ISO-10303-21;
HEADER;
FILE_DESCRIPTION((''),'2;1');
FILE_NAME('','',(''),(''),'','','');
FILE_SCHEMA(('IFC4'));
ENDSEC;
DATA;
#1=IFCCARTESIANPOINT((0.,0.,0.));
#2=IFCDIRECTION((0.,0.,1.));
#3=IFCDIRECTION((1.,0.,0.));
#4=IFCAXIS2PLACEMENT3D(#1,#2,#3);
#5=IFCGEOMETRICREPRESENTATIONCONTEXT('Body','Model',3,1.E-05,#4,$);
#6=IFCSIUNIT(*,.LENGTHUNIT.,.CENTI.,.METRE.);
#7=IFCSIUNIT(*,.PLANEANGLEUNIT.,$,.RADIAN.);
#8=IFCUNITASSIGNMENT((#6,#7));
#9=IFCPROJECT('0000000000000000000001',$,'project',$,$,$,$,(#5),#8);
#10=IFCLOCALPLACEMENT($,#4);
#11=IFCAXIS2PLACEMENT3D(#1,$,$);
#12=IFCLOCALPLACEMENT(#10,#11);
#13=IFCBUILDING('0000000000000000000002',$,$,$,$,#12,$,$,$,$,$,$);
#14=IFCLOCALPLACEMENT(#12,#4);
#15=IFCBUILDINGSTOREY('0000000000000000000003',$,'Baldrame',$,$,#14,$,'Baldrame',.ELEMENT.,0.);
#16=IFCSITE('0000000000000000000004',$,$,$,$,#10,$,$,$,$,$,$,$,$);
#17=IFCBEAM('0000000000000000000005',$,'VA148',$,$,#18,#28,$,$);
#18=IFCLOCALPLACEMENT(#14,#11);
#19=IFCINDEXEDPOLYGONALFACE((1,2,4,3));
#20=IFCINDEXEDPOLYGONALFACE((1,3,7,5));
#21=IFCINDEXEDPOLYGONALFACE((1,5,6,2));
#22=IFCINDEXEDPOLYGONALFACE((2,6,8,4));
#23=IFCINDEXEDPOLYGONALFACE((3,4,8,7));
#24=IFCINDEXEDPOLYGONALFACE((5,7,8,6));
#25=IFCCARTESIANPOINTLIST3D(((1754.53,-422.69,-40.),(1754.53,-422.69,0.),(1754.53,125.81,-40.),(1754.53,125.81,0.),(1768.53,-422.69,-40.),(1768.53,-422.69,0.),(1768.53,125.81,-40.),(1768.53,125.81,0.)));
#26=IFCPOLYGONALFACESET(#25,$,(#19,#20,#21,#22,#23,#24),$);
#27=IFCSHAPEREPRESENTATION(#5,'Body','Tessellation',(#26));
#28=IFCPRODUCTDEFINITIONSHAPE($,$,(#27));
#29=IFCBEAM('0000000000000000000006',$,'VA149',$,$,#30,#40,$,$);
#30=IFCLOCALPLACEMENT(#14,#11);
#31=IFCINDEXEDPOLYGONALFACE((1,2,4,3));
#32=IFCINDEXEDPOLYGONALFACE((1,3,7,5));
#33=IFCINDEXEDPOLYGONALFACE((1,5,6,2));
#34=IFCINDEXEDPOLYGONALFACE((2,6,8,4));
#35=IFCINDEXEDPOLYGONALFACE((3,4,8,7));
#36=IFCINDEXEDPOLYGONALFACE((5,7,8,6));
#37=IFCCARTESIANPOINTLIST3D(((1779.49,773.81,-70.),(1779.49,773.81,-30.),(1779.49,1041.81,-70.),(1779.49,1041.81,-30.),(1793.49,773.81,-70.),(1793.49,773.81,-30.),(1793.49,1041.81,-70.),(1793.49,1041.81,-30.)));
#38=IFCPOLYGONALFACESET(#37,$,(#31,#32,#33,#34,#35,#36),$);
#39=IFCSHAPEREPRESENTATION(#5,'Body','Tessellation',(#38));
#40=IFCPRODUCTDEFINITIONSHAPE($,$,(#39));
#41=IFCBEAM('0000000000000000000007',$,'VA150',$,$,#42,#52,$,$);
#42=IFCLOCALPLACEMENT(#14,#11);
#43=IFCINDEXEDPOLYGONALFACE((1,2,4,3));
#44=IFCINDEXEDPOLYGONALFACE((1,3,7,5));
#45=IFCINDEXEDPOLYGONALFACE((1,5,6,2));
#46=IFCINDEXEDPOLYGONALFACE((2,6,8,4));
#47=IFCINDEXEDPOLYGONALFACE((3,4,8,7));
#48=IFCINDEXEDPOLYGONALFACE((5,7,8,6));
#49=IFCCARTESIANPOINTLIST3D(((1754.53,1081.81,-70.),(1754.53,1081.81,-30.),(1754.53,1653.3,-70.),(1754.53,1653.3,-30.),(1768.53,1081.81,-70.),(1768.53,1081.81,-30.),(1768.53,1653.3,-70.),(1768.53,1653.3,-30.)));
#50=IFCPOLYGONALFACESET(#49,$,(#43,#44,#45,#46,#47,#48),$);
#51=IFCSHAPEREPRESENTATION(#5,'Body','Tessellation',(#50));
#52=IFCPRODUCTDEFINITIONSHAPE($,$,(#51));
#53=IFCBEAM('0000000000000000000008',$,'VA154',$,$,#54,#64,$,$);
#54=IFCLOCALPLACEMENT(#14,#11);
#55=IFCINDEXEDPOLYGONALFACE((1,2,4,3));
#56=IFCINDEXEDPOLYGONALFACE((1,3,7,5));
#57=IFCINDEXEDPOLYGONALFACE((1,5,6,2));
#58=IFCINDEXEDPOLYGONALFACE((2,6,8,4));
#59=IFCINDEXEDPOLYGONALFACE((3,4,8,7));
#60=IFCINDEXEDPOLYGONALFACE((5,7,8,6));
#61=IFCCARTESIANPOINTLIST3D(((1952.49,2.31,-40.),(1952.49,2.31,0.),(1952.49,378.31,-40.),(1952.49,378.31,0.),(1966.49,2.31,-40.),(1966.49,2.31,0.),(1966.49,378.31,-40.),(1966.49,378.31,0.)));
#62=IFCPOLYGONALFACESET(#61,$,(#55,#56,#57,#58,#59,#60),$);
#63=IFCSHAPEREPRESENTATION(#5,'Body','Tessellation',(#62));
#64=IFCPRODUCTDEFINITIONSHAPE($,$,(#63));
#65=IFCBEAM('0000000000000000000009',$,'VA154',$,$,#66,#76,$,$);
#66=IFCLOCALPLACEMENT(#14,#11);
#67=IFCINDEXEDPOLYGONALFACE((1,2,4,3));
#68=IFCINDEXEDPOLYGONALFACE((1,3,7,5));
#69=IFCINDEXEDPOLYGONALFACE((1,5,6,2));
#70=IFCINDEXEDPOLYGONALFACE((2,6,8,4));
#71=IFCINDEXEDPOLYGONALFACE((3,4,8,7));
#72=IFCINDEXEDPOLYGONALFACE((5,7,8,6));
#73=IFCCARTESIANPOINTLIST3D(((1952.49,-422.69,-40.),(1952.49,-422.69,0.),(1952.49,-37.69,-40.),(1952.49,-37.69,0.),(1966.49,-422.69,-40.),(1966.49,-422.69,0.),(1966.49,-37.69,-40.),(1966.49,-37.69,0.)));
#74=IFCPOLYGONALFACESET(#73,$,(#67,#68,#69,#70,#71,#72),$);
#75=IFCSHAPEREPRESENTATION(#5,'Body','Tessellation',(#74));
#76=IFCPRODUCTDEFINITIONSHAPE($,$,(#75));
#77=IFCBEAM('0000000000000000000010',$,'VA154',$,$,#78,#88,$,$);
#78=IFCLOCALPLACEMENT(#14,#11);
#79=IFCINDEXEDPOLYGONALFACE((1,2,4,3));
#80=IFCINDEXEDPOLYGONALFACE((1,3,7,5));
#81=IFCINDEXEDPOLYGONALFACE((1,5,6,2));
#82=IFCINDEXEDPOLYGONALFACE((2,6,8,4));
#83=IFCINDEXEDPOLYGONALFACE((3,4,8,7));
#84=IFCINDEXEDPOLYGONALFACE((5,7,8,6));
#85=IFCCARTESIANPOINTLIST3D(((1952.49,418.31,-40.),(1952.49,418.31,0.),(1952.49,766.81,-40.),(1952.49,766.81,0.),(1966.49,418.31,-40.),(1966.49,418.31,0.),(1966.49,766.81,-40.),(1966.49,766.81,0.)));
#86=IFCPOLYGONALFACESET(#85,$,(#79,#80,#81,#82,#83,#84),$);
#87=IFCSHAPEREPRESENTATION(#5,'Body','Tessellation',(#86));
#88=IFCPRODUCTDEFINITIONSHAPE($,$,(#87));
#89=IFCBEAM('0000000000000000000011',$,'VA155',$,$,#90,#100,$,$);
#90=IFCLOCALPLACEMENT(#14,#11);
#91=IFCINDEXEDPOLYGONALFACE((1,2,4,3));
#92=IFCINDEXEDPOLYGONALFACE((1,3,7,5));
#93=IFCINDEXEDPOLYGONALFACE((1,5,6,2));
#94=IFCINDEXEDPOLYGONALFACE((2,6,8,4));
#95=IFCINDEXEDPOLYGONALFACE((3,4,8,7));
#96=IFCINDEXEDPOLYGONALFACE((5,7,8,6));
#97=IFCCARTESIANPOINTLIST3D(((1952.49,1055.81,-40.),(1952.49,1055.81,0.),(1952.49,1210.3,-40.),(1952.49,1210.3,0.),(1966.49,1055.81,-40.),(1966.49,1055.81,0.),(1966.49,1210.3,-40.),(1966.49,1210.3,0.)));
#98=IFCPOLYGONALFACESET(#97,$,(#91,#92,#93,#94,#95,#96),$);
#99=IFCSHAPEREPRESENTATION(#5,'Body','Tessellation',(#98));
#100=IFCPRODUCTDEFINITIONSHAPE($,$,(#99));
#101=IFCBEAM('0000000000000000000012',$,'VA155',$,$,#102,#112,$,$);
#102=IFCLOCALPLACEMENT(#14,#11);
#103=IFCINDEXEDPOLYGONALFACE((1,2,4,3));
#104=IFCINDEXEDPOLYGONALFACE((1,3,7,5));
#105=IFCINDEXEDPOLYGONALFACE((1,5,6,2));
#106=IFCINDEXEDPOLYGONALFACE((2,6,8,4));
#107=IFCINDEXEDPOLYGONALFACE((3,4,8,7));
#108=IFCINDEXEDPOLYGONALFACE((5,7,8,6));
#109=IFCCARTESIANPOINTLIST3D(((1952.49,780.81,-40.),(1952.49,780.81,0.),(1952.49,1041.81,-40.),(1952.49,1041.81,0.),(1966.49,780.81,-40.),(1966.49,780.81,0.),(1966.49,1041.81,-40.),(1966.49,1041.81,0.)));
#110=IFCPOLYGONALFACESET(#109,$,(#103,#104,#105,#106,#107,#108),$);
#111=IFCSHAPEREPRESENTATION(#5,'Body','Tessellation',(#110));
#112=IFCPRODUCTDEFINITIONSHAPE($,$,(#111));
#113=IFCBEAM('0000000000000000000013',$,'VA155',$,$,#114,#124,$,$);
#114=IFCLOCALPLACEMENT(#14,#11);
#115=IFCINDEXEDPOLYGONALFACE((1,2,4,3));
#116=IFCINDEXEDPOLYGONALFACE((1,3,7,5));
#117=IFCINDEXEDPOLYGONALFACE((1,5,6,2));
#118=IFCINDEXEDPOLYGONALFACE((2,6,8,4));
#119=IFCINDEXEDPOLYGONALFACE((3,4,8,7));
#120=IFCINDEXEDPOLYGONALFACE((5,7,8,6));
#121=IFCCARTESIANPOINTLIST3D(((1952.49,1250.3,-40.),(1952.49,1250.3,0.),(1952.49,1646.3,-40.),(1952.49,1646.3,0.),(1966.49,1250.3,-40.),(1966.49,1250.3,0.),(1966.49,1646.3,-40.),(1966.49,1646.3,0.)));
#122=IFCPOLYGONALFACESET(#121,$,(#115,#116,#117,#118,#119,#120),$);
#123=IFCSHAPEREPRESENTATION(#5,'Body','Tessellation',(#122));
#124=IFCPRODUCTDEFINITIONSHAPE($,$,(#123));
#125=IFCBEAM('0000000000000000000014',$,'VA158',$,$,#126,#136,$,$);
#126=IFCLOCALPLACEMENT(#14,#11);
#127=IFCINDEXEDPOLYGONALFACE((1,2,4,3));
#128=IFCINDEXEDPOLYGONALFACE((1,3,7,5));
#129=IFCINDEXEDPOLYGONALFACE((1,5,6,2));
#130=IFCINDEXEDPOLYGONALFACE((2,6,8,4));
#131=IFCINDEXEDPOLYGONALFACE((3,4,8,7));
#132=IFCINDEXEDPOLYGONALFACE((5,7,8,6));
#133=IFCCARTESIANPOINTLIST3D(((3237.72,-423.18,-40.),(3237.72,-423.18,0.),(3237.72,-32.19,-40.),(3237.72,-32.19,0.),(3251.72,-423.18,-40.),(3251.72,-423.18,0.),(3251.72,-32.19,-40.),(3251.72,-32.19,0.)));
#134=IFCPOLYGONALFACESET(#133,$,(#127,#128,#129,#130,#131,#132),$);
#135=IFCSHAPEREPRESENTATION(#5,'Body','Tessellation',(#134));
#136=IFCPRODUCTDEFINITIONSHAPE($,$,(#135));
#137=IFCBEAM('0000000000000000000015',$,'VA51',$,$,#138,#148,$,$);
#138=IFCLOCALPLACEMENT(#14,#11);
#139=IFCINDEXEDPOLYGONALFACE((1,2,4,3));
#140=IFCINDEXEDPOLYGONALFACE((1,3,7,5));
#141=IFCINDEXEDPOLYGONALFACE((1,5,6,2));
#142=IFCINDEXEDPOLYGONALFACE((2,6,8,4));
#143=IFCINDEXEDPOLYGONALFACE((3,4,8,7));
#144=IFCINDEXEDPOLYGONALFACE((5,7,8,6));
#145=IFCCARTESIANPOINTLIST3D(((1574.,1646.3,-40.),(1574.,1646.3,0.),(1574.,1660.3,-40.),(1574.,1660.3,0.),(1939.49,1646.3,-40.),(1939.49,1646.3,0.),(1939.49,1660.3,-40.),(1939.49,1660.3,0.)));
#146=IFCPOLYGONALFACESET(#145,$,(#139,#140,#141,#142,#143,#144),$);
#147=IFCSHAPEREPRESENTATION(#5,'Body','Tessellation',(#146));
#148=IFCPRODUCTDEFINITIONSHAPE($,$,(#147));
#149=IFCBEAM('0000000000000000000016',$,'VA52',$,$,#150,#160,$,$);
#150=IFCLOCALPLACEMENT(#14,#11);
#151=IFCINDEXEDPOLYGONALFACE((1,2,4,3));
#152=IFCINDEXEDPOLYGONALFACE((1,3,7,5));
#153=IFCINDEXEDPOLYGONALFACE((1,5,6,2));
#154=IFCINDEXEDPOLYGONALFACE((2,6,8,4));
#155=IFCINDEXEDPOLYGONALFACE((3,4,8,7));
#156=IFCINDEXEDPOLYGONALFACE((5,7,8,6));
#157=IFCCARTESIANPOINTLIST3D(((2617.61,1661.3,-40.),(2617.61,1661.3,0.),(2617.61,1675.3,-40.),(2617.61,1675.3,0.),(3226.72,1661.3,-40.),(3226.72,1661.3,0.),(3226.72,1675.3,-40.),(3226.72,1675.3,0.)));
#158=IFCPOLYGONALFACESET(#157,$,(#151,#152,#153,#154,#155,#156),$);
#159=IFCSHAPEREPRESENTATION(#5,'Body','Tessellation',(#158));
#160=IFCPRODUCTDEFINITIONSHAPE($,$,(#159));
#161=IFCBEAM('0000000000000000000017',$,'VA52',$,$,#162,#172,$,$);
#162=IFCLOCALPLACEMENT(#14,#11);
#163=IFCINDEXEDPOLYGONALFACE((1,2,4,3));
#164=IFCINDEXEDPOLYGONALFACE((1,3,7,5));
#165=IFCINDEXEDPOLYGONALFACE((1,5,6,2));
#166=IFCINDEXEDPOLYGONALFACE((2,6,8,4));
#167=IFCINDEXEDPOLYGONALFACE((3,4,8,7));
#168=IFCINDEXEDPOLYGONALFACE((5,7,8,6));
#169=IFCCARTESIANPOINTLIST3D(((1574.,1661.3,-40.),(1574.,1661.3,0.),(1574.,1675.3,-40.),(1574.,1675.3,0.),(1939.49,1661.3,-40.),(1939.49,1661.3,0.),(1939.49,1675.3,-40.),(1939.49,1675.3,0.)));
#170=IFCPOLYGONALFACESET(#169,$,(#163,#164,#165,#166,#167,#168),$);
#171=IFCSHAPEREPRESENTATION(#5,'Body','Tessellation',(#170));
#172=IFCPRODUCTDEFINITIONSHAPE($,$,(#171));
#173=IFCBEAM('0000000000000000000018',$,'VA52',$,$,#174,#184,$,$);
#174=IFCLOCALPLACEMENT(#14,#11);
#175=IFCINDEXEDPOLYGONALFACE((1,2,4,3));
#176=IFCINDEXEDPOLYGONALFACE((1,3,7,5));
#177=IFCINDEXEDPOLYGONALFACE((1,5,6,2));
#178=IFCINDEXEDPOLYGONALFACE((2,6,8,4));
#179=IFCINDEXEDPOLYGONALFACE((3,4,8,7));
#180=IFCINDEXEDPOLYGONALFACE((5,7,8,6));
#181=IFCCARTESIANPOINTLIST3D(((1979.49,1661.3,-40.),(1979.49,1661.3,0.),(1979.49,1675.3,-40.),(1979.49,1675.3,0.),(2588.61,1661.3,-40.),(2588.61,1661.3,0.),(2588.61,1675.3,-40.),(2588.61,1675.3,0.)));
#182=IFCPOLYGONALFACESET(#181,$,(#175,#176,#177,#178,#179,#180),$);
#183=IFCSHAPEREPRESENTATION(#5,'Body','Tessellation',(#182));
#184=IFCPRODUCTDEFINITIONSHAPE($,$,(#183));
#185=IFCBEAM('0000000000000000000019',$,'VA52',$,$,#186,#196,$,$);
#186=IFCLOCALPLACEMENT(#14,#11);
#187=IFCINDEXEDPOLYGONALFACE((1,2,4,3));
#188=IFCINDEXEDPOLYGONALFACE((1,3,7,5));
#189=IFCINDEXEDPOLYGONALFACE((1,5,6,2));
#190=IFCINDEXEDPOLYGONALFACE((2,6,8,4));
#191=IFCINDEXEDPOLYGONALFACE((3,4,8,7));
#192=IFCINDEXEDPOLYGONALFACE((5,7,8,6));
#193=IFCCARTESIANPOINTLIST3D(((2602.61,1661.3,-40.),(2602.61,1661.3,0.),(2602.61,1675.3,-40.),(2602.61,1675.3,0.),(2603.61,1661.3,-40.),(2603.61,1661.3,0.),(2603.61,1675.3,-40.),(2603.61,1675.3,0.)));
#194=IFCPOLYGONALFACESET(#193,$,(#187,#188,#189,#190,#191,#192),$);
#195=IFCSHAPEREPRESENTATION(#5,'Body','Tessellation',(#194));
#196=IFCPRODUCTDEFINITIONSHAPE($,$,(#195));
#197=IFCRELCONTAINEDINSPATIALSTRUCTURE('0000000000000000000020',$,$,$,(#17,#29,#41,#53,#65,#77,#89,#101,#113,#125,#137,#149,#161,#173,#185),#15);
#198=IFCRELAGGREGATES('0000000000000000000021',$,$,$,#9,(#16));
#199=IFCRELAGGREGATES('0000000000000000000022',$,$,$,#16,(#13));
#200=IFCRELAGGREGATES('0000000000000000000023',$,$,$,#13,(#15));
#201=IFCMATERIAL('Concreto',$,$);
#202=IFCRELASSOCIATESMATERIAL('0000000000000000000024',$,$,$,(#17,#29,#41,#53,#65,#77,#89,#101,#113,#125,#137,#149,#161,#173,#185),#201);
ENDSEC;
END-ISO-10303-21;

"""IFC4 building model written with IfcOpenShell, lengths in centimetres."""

from ifc_helpers import new_model, si_unit, frame, origin, origin_with_axes, origin_2d_with_axis, place, context, project, spatial, rectangle, extrude, material, element, save


model = new_model("IFC4")

# Units and contexts
model_context = context("Model", 3, precision=1e-05, world=origin_with_axes(), identifier="Body")
ifc_project = project(units=[si_unit("LENGTHUNIT", "METRE", prefix="CENTI"), si_unit("PLANEANGLEUNIT", "RADIAN")], contexts=[model_context])

# Site, building, storey
site_placement = place(None, origin_with_axes())
site = spatial("IfcSite", under=ifc_project, at=site_placement)
building_placement = place(site_placement, origin())
building = spatial("IfcBuilding", under=site, at=building_placement)
storey_placement = place(building_placement, origin_with_axes())
storey = spatial("IfcBuildingStorey", under=building, at=storey_placement, Name="Baldrame", LongName="Baldrame", CompositionType="ELEMENT", Elevation=0.0)

# Shared definitions
ifc_material = material(Name="Concreto")

# Beams
beam_1_placement = place(storey_placement, frame((1761.53, -148.44, 0.0), z_axis=(0.0, 0.0, 1.0), x_axis=(1.0, 0.0, 0.0)))
element("IfcBeam", 1, at=beam_1_placement, inside=storey, material=ifc_material, Name="VA148", context=model_context, shape_type="SolidModel", body=[
    extrude(rectangle(XDim=14.0, YDim=40.0, at=origin_2d_with_axis()), frame((0.0, -274.25, -20.0), z_axis=(0.0, 1.0, 0.0), x_axis=(1.0, 0.0, 0.0)), (0.0, 0.0, 1.0), 548.5),
])
beam_2_placement = place(storey_placement, frame((1786.49, 907.81, -30.0), z_axis=(0.0, 0.0, 1.0), x_axis=(1.0, 0.0, 0.0)))
element("IfcBeam", 2, at=beam_2_placement, inside=storey, material=ifc_material, Name="VA149", context=model_context, shape_type="SolidModel", body=[
    extrude(rectangle(XDim=14.0, YDim=40.0, at=origin_2d_with_axis()), frame((0.0, -134.0, -20.0), z_axis=(0.0, 1.0, 0.0), x_axis=(1.0, 0.0, 0.0)), (0.0, 0.0, 1.0), 268.0),
])
beam_3_placement = place(storey_placement, frame((1761.53, 1367.56, -30.0), z_axis=(0.0, 0.0, 1.0), x_axis=(1.0, 0.0, 0.0)))
element("IfcBeam", 3, at=beam_3_placement, inside=storey, material=ifc_material, Name="VA150", context=model_context, shape_type="SolidModel", body=[
    extrude(rectangle(XDim=14.0, YDim=40.0, at=origin_2d_with_axis()), frame((0.0, -285.75, -20.0), z_axis=(0.0, 1.0, 0.0), x_axis=(1.0, 0.0, 0.0)), (0.0, 0.0, 1.0), 571.49),
])
beam_4_placement = place(storey_placement, frame((1959.49, 190.31, 0.0), z_axis=(0.0, 0.0, 1.0), x_axis=(1.0, 0.0, 0.0)))
element("IfcBeam", 4, at=beam_4_placement, inside=storey, material=ifc_material, Name="VA154", context=model_context, shape_type="SolidModel", body=[
    extrude(rectangle(XDim=14.0, YDim=40.0, at=origin_2d_with_axis()), frame((0.0, -188.0, -20.0), z_axis=(0.0, 1.0, 0.0), x_axis=(1.0, 0.0, 0.0)), (0.0, 0.0, 1.0), 376.0),
])
beam_5_placement = place(storey_placement, frame((1959.49, -230.19, 0.0), z_axis=(0.0, 0.0, 1.0), x_axis=(1.0, 0.0, 0.0)))
element("IfcBeam", 5, at=beam_5_placement, inside=storey, material=ifc_material, Name="VA154", context=model_context, shape_type="SolidModel", body=[
    extrude(rectangle(XDim=14.0, YDim=40.0, at=origin_2d_with_axis()), frame((0.0, -192.5, -20.0), z_axis=(0.0, 1.0, 0.0), x_axis=(1.0, 0.0, 0.0)), (0.0, 0.0, 1.0), 385.0),
])
beam_6_placement = place(storey_placement, frame((1959.49, 592.56, 0.0), z_axis=(0.0, 0.0, 1.0), x_axis=(1.0, 0.0, 0.0)))
element("IfcBeam", 6, at=beam_6_placement, inside=storey, material=ifc_material, Name="VA154", context=model_context, shape_type="SolidModel", body=[
    extrude(rectangle(XDim=14.0, YDim=40.0, at=origin_2d_with_axis()), frame((0.0, -174.25, -20.0), z_axis=(0.0, 1.0, 0.0), x_axis=(1.0, 0.0, 0.0)), (0.0, 0.0, 1.0), 348.5),
])
beam_7_placement = place(storey_placement, frame((1959.49, 1133.06, 0.0), z_axis=(0.0, 0.0, 1.0), x_axis=(1.0, 0.0, 0.0)))
element("IfcBeam", 7, at=beam_7_placement, inside=storey, material=ifc_material, Name="VA155", context=model_context, shape_type="SolidModel", body=[
    extrude(rectangle(XDim=14.0, YDim=40.0, at=origin_2d_with_axis()), frame((0.0, -77.25, -20.0), z_axis=(0.0, 1.0, 0.0), x_axis=(1.0, 0.0, 0.0)), (0.0, 0.0, 1.0), 154.49),
])
beam_8_placement = place(storey_placement, frame((1959.49, 911.31, 0.0), z_axis=(0.0, 0.0, 1.0), x_axis=(1.0, 0.0, 0.0)))
element("IfcBeam", 8, at=beam_8_placement, inside=storey, material=ifc_material, Name="VA155", context=model_context, shape_type="SolidModel", body=[
    extrude(rectangle(XDim=14.0, YDim=40.0, at=origin_2d_with_axis()), frame((0.0, -130.5, -20.0), z_axis=(0.0, 1.0, 0.0), x_axis=(1.0, 0.0, 0.0)), (0.0, 0.0, 1.0), 261.0),
])
beam_9_placement = place(storey_placement, frame((1959.49, 1448.3, 0.0), z_axis=(0.0, 0.0, 1.0), x_axis=(1.0, 0.0, 0.0)))
element("IfcBeam", 9, at=beam_9_placement, inside=storey, material=ifc_material, Name="VA155", context=model_context, shape_type="SolidModel", body=[
    extrude(rectangle(XDim=14.0, YDim=40.0, at=origin_2d_with_axis()), frame((0.0, -198.0, -20.0), z_axis=(0.0, 1.0, 0.0), x_axis=(1.0, 0.0, 0.0)), (0.0, 0.0, 1.0), 396.0),
])
beam_10_placement = place(storey_placement, frame((3244.72, -227.69, 0.0), z_axis=(0.0, 0.0, 1.0), x_axis=(1.0, 0.0, 0.0)))
element("IfcBeam", 10, at=beam_10_placement, inside=storey, material=ifc_material, Name="VA158", context=model_context, shape_type="SolidModel", body=[
    extrude(rectangle(XDim=14.0, YDim=40.0, at=origin_2d_with_axis()), frame((0.0, -195.5, -20.0), z_axis=(0.0, 1.0, 0.0), x_axis=(1.0, 0.0, 0.0)), (0.0, 0.0, 1.0), 390.99),
])
beam_11_placement = place(storey_placement, frame((1756.74, 1653.3, 0.0), z_axis=(0.0, 0.0, 1.0), x_axis=(1.0, 0.0, 0.0)))
element("IfcBeam", 11, at=beam_11_placement, inside=storey, material=ifc_material, Name="VA51", context=model_context, shape_type="SolidModel", body=[
    extrude(rectangle(XDim=14.0, YDim=40.0, at=origin_2d_with_axis()), frame((-182.75, 0.0, -20.0), z_axis=(1.0, 0.0, 0.0), x_axis=(0.0, 1.0, 0.0)), (0.0, 0.0, 1.0), 365.49),
])
beam_12_placement = place(storey_placement, frame((2922.16, 1668.3, 0.0), z_axis=(0.0, 0.0, 1.0), x_axis=(1.0, 0.0, 0.0)))
element("IfcBeam", 12, at=beam_12_placement, inside=storey, material=ifc_material, Name="VA52", context=model_context, shape_type="SolidModel", body=[
    extrude(rectangle(XDim=14.0, YDim=40.0, at=origin_2d_with_axis()), frame((-304.56, 0.0, -20.0), z_axis=(1.0, 0.0, 0.0), x_axis=(0.0, 1.0, 0.0)), (0.0, 0.0, 1.0), 609.11),
])
beam_13_placement = place(storey_placement, frame((1756.74, 1668.3, 0.0), z_axis=(0.0, 0.0, 1.0), x_axis=(1.0, 0.0, 0.0)))
element("IfcBeam", 13, at=beam_13_placement, inside=storey, material=ifc_material, Name="VA52", context=model_context, shape_type="SolidModel", body=[
    extrude(rectangle(XDim=14.0, YDim=40.0, at=origin_2d_with_axis()), frame((-182.75, 0.0, -20.0), z_axis=(1.0, 0.0, 0.0), x_axis=(0.0, 1.0, 0.0)), (0.0, 0.0, 1.0), 365.49),
])
beam_14_placement = place(storey_placement, frame((2284.05, 1668.3, 0.0), z_axis=(0.0, 0.0, 1.0), x_axis=(1.0, 0.0, 0.0)))
element("IfcBeam", 14, at=beam_14_placement, inside=storey, material=ifc_material, Name="VA52", context=model_context, shape_type="SolidModel", body=[
    extrude(rectangle(XDim=14.0, YDim=40.0, at=origin_2d_with_axis()), frame((-304.56, 0.0, -20.0), z_axis=(1.0, 0.0, 0.0), x_axis=(0.0, 1.0, 0.0)), (0.0, 0.0, 1.0), 609.12),
])
beam_15_placement = place(storey_placement, frame((2603.11, 1668.3, 0.0), z_axis=(0.0, 0.0, 1.0), x_axis=(1.0, 0.0, 0.0)))
element("IfcBeam", 15, at=beam_15_placement, inside=storey, material=ifc_material, Name="VA52", context=model_context, shape_type="SolidModel", body=[
    extrude(rectangle(XDim=14.0, YDim=40.0, at=origin_2d_with_axis()), frame((-0.5, 0.0, -20.0), z_axis=(1.0, 0.0, 0.0), x_axis=(0.0, 1.0, 0.0)), (0.0, 0.0, 1.0), 1.0),
])

save(model, "model.ifc")
